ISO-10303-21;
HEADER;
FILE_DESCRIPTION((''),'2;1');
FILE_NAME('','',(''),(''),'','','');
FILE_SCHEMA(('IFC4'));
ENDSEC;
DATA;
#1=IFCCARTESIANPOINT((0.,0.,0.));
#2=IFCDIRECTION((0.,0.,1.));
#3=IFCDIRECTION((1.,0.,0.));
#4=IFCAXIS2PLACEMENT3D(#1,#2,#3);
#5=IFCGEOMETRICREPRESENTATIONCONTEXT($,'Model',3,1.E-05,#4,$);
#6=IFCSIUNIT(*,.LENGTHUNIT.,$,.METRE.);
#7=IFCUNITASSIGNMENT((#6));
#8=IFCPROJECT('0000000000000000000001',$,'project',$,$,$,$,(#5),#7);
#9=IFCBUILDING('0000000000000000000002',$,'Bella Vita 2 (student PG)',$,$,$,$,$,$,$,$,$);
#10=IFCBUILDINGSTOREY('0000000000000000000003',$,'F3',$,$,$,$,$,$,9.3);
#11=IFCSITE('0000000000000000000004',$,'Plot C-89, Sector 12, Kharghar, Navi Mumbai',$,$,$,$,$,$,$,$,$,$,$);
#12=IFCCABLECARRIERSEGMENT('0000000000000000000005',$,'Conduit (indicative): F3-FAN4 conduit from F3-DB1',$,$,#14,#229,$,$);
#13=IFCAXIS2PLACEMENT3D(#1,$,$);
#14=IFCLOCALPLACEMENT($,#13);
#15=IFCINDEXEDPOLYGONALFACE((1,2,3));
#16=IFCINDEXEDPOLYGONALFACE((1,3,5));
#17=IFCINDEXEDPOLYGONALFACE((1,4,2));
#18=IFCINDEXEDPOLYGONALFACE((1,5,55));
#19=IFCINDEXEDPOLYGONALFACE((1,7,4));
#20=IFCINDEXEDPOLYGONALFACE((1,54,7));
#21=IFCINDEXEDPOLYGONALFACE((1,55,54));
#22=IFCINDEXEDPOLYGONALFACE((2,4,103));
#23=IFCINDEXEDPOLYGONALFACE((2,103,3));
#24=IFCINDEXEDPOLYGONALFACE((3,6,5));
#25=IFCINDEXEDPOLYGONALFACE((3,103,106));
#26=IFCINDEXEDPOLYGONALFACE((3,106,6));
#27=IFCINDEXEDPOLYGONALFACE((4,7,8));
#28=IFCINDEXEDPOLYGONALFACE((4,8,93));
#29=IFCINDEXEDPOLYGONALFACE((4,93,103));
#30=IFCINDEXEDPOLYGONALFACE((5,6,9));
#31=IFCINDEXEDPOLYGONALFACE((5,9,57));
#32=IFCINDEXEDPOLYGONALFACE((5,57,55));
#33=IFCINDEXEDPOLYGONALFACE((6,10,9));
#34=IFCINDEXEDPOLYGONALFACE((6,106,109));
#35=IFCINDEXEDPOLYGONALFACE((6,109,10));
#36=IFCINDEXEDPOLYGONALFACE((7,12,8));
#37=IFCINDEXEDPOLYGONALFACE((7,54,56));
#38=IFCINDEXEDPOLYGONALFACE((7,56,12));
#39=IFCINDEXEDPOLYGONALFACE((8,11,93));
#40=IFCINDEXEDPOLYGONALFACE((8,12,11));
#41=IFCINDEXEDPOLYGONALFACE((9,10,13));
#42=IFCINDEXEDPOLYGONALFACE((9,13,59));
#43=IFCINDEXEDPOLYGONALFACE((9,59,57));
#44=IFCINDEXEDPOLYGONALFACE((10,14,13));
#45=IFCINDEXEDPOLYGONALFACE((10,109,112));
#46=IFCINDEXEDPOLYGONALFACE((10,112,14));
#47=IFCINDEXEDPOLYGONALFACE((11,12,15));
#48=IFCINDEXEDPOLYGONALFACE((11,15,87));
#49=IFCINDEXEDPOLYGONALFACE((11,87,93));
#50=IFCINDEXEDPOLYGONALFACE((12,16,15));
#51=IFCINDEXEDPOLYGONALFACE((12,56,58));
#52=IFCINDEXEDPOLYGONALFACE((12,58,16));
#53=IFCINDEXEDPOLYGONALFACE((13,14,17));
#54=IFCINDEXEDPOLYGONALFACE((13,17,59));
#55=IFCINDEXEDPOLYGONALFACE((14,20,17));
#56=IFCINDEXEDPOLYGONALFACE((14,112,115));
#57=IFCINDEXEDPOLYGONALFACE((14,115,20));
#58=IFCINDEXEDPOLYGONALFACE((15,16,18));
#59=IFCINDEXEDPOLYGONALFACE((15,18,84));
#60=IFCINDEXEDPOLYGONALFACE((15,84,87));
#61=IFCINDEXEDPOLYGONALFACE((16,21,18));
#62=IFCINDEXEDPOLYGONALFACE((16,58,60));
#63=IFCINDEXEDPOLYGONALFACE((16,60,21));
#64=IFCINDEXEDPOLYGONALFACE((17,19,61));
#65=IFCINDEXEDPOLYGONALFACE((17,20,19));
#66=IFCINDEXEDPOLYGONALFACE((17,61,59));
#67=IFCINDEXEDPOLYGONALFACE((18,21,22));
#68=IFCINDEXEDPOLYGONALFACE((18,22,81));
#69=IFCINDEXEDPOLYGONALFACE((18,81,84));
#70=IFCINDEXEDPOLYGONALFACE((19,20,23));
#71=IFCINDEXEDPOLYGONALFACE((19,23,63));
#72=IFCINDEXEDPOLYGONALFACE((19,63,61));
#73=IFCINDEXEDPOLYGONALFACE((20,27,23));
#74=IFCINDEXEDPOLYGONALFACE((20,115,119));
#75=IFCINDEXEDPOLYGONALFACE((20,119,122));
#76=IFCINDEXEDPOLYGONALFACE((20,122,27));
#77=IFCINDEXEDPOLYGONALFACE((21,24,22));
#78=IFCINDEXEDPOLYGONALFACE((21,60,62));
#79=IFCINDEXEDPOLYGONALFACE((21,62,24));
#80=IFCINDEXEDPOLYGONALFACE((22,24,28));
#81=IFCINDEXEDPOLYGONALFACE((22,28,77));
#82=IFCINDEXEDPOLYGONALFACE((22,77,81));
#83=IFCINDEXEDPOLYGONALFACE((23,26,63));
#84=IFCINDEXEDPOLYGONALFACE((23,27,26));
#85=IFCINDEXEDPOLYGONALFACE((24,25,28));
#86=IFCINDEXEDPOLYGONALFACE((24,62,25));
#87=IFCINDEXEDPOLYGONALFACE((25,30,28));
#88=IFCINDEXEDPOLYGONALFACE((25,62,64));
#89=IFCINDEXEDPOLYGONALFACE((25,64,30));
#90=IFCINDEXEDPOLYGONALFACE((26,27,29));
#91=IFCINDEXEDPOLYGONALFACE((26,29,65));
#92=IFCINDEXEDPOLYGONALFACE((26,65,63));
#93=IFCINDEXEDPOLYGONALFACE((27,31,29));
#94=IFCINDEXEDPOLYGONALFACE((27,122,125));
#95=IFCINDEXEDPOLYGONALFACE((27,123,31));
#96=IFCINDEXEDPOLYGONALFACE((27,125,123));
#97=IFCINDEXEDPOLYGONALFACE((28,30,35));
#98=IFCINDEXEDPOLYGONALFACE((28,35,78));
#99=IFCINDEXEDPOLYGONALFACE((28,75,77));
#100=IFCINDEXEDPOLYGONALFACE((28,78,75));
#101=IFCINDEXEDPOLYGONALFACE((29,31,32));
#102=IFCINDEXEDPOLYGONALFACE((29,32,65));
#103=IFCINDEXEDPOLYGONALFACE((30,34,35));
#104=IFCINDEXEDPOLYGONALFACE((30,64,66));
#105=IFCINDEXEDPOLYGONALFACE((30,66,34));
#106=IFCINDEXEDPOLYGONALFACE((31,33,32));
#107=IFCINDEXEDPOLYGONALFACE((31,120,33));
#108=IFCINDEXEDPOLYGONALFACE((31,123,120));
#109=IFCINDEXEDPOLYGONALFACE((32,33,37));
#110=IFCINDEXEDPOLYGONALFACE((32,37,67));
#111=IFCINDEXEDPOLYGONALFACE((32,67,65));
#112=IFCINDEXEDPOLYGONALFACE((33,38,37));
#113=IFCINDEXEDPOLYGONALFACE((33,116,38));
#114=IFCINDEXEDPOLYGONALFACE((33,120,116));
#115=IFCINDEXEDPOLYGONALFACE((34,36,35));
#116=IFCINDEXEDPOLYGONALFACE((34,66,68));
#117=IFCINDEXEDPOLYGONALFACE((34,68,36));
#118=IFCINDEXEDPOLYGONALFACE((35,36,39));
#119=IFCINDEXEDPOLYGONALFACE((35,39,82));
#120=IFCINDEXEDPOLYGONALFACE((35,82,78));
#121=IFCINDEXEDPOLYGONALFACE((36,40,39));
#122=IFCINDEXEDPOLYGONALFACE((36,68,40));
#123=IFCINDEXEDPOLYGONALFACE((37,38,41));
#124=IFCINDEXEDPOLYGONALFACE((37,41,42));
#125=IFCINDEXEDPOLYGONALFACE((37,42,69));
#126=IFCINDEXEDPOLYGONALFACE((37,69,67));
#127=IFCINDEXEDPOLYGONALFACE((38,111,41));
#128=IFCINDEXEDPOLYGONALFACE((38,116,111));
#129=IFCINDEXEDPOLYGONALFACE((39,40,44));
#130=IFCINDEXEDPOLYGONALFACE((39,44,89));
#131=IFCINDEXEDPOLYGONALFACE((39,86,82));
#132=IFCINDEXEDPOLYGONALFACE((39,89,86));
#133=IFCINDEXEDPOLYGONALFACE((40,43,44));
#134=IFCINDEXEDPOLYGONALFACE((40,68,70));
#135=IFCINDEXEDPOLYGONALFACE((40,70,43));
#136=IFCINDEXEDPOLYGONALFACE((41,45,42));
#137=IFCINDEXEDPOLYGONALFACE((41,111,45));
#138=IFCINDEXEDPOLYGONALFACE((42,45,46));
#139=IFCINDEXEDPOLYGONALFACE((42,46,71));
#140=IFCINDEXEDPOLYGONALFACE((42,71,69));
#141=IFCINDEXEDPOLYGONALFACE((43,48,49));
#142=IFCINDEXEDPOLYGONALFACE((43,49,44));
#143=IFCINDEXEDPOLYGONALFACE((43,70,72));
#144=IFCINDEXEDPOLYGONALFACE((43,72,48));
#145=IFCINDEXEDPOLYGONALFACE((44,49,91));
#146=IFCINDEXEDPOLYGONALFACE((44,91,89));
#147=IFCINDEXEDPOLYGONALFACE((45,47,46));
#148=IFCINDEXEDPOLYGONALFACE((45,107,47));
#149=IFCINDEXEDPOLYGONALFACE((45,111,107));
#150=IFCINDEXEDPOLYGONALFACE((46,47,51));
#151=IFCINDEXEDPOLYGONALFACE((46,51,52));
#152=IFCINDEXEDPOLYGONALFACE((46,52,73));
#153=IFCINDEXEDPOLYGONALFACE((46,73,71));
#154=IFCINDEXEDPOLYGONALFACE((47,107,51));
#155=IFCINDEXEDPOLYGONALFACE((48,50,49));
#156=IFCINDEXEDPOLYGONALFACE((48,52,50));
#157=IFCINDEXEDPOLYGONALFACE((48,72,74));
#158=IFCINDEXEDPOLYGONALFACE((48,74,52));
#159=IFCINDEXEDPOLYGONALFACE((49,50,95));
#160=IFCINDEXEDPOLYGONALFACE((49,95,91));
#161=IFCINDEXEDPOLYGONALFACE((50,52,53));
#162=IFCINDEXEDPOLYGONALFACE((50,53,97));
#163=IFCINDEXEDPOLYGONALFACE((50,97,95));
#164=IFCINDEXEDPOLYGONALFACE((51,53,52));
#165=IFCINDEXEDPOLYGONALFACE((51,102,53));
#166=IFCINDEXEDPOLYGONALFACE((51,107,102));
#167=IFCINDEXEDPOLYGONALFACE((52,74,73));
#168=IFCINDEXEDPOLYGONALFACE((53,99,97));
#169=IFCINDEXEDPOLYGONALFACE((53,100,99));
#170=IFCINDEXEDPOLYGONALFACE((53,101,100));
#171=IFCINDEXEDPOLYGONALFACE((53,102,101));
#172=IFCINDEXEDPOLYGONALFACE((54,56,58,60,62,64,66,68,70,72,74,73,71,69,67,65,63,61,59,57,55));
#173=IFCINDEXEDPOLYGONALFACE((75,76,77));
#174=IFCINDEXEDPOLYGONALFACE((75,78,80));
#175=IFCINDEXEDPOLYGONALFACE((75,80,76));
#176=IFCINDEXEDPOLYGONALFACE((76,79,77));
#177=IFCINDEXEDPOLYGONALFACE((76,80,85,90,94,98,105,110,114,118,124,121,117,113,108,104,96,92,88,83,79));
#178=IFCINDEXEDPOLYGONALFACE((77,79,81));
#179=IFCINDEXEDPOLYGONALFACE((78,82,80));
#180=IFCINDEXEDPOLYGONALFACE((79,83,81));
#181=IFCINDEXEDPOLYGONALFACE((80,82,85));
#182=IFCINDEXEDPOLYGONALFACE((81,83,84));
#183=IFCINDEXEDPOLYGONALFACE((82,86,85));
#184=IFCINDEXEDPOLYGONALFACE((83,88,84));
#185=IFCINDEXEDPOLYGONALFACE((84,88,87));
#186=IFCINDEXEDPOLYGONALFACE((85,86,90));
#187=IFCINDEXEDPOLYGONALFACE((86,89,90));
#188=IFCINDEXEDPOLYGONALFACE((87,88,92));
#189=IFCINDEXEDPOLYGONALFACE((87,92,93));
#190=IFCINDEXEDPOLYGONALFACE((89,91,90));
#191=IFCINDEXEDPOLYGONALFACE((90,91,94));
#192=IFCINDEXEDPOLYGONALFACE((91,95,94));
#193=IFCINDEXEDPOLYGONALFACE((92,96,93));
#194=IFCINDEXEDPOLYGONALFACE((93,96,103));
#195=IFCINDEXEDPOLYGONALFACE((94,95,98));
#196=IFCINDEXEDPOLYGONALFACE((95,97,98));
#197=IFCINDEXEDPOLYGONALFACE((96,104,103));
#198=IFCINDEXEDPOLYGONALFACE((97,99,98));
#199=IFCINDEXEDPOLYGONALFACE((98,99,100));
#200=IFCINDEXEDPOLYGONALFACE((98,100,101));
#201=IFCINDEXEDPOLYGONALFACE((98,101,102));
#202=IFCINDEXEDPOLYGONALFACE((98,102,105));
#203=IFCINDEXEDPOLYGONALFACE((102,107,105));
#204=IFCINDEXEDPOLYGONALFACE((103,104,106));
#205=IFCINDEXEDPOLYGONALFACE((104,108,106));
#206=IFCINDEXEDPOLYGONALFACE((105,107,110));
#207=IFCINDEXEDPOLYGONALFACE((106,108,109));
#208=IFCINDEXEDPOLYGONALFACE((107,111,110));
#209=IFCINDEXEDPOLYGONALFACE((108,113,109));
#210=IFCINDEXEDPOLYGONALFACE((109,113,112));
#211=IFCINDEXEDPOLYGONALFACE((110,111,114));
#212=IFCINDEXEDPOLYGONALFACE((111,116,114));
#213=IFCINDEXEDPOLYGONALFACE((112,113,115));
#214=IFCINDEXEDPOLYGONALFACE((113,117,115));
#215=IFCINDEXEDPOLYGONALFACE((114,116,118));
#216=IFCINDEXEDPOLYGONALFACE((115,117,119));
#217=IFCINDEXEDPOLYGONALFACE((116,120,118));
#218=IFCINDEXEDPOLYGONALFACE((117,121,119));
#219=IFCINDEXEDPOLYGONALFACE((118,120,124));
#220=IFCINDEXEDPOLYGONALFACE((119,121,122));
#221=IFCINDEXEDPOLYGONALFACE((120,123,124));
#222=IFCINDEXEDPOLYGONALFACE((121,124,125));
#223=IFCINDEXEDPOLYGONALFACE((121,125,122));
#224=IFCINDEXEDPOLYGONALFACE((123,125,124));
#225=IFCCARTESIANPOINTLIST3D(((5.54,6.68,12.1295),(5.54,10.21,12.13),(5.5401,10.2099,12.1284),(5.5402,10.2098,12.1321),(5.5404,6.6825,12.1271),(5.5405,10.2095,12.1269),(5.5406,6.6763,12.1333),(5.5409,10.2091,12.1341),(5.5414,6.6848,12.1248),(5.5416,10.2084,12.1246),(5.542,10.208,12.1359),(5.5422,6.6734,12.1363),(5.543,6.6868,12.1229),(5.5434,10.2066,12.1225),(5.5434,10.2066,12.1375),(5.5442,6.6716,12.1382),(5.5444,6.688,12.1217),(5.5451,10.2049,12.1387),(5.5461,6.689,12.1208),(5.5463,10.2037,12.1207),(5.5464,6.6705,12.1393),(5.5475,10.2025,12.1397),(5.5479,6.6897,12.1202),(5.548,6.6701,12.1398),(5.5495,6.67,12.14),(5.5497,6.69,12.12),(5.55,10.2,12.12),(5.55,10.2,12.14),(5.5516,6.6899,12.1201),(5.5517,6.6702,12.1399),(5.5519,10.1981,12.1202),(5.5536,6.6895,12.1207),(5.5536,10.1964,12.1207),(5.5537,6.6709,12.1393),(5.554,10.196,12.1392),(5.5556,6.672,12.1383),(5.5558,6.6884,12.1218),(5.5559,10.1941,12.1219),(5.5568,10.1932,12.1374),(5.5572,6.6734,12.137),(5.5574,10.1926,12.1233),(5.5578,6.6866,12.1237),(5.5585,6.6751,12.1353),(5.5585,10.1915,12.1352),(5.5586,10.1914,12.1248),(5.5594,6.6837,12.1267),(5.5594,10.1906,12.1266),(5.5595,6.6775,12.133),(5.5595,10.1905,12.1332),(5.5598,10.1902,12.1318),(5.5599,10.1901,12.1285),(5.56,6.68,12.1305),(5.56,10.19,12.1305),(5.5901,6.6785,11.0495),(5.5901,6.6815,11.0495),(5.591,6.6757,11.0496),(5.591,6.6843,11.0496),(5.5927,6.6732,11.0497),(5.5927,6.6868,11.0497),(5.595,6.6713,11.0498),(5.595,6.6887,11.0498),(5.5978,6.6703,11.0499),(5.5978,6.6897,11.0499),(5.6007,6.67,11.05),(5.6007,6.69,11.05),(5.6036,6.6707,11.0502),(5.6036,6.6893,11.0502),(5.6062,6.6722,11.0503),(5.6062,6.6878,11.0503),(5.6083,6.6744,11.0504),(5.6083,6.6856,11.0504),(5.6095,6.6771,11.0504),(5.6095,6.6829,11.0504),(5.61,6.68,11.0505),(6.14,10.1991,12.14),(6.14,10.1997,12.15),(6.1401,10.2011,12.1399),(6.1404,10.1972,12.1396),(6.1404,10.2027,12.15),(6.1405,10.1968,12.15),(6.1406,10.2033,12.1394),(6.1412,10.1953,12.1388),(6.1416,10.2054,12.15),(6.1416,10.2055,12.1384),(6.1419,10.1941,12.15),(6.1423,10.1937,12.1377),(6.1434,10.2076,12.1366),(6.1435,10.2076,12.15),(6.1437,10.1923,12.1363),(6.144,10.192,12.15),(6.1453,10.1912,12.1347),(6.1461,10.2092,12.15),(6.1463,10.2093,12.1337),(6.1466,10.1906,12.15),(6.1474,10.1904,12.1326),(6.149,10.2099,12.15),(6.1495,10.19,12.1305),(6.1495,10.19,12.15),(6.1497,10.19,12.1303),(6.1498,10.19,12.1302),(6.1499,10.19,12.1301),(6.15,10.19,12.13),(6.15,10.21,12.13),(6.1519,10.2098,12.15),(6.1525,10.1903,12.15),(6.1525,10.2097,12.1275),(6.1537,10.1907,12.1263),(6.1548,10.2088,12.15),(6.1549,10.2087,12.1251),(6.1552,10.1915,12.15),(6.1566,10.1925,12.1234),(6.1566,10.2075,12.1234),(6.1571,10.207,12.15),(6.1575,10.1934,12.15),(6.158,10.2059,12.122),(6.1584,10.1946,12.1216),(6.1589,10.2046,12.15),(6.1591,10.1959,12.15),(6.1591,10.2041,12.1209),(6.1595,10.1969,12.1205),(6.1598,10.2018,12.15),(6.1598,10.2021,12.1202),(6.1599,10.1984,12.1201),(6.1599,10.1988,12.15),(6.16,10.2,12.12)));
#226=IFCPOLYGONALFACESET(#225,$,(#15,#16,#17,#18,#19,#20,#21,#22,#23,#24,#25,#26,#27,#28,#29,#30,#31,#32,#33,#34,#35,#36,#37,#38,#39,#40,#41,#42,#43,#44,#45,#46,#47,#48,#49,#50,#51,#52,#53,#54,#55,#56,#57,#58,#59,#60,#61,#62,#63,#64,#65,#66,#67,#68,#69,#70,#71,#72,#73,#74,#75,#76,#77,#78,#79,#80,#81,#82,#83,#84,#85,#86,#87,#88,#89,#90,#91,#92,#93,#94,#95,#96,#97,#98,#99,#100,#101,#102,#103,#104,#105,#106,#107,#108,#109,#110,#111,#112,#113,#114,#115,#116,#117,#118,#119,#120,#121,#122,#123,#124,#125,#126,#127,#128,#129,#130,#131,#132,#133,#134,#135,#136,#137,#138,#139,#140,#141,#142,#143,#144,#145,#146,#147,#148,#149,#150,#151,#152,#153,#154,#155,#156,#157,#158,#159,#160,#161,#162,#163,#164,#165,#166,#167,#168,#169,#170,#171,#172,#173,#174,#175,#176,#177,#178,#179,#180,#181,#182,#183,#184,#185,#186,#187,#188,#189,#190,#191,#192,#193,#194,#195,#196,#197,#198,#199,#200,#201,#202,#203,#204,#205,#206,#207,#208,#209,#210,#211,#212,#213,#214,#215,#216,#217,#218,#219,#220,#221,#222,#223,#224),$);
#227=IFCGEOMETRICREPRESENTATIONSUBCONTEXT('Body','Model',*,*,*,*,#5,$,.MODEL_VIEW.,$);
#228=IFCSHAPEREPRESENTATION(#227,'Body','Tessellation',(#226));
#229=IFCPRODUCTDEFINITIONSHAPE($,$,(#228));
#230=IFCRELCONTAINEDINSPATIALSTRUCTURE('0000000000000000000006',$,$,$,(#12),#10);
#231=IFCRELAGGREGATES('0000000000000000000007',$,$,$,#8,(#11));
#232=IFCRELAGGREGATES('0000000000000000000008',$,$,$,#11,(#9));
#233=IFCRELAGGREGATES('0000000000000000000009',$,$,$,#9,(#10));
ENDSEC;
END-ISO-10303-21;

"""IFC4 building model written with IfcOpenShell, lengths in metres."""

from ifc_helpers import new_model, entity, si_unit, origin, origin_with_axes, place, context, subcontext, project, spatial, element, save


model = new_model("IFC4")

# Units and contexts
model_context = context("Model", 3, precision=1e-05, world=origin_with_axes())
body_context = subcontext(model_context, "Body", "Model", "MODEL_VIEW")
ifc_project = project(units=[si_unit("LENGTHUNIT", "METRE")], contexts=[model_context])

# Site, building, storey
site = spatial("IfcSite", under=ifc_project, Name="Plot C-89, Sector 12, Kharghar, Navi Mumbai")
building = spatial("IfcBuilding", under=site, Name="Bella Vita 2 (student PG)")
storey = spatial("IfcBuildingStorey", under=building, Name="F3", Elevation=9.3)

# Cable carrier segment
cable_carrier_segment_1_placement = place(None, origin())
element("IfcCableCarrierSegment", 1, at=cable_carrier_segment_1_placement, inside=storey, Name="Conduit (indicative): F3-FAN4 conduit from F3-DB1", context=body_context, shape_type="AdvancedSweptSolid", body=[
    entity("IfcSweptDiskSolid", entity("IfcPolyline", [entity("IfcCartesianPoint", [5.6, 6.68, 11.05]), entity("IfcCartesianPoint", [5.55, 6.68, 12.13]), entity("IfcCartesianPoint", [5.55, 10.2, 12.13]), entity("IfcCartesianPoint", [6.15, 10.2, 12.13]), entity("IfcCartesianPoint", [6.15, 10.2, 12.15])]), 0.01),
])

save(model, "model.ifc")
